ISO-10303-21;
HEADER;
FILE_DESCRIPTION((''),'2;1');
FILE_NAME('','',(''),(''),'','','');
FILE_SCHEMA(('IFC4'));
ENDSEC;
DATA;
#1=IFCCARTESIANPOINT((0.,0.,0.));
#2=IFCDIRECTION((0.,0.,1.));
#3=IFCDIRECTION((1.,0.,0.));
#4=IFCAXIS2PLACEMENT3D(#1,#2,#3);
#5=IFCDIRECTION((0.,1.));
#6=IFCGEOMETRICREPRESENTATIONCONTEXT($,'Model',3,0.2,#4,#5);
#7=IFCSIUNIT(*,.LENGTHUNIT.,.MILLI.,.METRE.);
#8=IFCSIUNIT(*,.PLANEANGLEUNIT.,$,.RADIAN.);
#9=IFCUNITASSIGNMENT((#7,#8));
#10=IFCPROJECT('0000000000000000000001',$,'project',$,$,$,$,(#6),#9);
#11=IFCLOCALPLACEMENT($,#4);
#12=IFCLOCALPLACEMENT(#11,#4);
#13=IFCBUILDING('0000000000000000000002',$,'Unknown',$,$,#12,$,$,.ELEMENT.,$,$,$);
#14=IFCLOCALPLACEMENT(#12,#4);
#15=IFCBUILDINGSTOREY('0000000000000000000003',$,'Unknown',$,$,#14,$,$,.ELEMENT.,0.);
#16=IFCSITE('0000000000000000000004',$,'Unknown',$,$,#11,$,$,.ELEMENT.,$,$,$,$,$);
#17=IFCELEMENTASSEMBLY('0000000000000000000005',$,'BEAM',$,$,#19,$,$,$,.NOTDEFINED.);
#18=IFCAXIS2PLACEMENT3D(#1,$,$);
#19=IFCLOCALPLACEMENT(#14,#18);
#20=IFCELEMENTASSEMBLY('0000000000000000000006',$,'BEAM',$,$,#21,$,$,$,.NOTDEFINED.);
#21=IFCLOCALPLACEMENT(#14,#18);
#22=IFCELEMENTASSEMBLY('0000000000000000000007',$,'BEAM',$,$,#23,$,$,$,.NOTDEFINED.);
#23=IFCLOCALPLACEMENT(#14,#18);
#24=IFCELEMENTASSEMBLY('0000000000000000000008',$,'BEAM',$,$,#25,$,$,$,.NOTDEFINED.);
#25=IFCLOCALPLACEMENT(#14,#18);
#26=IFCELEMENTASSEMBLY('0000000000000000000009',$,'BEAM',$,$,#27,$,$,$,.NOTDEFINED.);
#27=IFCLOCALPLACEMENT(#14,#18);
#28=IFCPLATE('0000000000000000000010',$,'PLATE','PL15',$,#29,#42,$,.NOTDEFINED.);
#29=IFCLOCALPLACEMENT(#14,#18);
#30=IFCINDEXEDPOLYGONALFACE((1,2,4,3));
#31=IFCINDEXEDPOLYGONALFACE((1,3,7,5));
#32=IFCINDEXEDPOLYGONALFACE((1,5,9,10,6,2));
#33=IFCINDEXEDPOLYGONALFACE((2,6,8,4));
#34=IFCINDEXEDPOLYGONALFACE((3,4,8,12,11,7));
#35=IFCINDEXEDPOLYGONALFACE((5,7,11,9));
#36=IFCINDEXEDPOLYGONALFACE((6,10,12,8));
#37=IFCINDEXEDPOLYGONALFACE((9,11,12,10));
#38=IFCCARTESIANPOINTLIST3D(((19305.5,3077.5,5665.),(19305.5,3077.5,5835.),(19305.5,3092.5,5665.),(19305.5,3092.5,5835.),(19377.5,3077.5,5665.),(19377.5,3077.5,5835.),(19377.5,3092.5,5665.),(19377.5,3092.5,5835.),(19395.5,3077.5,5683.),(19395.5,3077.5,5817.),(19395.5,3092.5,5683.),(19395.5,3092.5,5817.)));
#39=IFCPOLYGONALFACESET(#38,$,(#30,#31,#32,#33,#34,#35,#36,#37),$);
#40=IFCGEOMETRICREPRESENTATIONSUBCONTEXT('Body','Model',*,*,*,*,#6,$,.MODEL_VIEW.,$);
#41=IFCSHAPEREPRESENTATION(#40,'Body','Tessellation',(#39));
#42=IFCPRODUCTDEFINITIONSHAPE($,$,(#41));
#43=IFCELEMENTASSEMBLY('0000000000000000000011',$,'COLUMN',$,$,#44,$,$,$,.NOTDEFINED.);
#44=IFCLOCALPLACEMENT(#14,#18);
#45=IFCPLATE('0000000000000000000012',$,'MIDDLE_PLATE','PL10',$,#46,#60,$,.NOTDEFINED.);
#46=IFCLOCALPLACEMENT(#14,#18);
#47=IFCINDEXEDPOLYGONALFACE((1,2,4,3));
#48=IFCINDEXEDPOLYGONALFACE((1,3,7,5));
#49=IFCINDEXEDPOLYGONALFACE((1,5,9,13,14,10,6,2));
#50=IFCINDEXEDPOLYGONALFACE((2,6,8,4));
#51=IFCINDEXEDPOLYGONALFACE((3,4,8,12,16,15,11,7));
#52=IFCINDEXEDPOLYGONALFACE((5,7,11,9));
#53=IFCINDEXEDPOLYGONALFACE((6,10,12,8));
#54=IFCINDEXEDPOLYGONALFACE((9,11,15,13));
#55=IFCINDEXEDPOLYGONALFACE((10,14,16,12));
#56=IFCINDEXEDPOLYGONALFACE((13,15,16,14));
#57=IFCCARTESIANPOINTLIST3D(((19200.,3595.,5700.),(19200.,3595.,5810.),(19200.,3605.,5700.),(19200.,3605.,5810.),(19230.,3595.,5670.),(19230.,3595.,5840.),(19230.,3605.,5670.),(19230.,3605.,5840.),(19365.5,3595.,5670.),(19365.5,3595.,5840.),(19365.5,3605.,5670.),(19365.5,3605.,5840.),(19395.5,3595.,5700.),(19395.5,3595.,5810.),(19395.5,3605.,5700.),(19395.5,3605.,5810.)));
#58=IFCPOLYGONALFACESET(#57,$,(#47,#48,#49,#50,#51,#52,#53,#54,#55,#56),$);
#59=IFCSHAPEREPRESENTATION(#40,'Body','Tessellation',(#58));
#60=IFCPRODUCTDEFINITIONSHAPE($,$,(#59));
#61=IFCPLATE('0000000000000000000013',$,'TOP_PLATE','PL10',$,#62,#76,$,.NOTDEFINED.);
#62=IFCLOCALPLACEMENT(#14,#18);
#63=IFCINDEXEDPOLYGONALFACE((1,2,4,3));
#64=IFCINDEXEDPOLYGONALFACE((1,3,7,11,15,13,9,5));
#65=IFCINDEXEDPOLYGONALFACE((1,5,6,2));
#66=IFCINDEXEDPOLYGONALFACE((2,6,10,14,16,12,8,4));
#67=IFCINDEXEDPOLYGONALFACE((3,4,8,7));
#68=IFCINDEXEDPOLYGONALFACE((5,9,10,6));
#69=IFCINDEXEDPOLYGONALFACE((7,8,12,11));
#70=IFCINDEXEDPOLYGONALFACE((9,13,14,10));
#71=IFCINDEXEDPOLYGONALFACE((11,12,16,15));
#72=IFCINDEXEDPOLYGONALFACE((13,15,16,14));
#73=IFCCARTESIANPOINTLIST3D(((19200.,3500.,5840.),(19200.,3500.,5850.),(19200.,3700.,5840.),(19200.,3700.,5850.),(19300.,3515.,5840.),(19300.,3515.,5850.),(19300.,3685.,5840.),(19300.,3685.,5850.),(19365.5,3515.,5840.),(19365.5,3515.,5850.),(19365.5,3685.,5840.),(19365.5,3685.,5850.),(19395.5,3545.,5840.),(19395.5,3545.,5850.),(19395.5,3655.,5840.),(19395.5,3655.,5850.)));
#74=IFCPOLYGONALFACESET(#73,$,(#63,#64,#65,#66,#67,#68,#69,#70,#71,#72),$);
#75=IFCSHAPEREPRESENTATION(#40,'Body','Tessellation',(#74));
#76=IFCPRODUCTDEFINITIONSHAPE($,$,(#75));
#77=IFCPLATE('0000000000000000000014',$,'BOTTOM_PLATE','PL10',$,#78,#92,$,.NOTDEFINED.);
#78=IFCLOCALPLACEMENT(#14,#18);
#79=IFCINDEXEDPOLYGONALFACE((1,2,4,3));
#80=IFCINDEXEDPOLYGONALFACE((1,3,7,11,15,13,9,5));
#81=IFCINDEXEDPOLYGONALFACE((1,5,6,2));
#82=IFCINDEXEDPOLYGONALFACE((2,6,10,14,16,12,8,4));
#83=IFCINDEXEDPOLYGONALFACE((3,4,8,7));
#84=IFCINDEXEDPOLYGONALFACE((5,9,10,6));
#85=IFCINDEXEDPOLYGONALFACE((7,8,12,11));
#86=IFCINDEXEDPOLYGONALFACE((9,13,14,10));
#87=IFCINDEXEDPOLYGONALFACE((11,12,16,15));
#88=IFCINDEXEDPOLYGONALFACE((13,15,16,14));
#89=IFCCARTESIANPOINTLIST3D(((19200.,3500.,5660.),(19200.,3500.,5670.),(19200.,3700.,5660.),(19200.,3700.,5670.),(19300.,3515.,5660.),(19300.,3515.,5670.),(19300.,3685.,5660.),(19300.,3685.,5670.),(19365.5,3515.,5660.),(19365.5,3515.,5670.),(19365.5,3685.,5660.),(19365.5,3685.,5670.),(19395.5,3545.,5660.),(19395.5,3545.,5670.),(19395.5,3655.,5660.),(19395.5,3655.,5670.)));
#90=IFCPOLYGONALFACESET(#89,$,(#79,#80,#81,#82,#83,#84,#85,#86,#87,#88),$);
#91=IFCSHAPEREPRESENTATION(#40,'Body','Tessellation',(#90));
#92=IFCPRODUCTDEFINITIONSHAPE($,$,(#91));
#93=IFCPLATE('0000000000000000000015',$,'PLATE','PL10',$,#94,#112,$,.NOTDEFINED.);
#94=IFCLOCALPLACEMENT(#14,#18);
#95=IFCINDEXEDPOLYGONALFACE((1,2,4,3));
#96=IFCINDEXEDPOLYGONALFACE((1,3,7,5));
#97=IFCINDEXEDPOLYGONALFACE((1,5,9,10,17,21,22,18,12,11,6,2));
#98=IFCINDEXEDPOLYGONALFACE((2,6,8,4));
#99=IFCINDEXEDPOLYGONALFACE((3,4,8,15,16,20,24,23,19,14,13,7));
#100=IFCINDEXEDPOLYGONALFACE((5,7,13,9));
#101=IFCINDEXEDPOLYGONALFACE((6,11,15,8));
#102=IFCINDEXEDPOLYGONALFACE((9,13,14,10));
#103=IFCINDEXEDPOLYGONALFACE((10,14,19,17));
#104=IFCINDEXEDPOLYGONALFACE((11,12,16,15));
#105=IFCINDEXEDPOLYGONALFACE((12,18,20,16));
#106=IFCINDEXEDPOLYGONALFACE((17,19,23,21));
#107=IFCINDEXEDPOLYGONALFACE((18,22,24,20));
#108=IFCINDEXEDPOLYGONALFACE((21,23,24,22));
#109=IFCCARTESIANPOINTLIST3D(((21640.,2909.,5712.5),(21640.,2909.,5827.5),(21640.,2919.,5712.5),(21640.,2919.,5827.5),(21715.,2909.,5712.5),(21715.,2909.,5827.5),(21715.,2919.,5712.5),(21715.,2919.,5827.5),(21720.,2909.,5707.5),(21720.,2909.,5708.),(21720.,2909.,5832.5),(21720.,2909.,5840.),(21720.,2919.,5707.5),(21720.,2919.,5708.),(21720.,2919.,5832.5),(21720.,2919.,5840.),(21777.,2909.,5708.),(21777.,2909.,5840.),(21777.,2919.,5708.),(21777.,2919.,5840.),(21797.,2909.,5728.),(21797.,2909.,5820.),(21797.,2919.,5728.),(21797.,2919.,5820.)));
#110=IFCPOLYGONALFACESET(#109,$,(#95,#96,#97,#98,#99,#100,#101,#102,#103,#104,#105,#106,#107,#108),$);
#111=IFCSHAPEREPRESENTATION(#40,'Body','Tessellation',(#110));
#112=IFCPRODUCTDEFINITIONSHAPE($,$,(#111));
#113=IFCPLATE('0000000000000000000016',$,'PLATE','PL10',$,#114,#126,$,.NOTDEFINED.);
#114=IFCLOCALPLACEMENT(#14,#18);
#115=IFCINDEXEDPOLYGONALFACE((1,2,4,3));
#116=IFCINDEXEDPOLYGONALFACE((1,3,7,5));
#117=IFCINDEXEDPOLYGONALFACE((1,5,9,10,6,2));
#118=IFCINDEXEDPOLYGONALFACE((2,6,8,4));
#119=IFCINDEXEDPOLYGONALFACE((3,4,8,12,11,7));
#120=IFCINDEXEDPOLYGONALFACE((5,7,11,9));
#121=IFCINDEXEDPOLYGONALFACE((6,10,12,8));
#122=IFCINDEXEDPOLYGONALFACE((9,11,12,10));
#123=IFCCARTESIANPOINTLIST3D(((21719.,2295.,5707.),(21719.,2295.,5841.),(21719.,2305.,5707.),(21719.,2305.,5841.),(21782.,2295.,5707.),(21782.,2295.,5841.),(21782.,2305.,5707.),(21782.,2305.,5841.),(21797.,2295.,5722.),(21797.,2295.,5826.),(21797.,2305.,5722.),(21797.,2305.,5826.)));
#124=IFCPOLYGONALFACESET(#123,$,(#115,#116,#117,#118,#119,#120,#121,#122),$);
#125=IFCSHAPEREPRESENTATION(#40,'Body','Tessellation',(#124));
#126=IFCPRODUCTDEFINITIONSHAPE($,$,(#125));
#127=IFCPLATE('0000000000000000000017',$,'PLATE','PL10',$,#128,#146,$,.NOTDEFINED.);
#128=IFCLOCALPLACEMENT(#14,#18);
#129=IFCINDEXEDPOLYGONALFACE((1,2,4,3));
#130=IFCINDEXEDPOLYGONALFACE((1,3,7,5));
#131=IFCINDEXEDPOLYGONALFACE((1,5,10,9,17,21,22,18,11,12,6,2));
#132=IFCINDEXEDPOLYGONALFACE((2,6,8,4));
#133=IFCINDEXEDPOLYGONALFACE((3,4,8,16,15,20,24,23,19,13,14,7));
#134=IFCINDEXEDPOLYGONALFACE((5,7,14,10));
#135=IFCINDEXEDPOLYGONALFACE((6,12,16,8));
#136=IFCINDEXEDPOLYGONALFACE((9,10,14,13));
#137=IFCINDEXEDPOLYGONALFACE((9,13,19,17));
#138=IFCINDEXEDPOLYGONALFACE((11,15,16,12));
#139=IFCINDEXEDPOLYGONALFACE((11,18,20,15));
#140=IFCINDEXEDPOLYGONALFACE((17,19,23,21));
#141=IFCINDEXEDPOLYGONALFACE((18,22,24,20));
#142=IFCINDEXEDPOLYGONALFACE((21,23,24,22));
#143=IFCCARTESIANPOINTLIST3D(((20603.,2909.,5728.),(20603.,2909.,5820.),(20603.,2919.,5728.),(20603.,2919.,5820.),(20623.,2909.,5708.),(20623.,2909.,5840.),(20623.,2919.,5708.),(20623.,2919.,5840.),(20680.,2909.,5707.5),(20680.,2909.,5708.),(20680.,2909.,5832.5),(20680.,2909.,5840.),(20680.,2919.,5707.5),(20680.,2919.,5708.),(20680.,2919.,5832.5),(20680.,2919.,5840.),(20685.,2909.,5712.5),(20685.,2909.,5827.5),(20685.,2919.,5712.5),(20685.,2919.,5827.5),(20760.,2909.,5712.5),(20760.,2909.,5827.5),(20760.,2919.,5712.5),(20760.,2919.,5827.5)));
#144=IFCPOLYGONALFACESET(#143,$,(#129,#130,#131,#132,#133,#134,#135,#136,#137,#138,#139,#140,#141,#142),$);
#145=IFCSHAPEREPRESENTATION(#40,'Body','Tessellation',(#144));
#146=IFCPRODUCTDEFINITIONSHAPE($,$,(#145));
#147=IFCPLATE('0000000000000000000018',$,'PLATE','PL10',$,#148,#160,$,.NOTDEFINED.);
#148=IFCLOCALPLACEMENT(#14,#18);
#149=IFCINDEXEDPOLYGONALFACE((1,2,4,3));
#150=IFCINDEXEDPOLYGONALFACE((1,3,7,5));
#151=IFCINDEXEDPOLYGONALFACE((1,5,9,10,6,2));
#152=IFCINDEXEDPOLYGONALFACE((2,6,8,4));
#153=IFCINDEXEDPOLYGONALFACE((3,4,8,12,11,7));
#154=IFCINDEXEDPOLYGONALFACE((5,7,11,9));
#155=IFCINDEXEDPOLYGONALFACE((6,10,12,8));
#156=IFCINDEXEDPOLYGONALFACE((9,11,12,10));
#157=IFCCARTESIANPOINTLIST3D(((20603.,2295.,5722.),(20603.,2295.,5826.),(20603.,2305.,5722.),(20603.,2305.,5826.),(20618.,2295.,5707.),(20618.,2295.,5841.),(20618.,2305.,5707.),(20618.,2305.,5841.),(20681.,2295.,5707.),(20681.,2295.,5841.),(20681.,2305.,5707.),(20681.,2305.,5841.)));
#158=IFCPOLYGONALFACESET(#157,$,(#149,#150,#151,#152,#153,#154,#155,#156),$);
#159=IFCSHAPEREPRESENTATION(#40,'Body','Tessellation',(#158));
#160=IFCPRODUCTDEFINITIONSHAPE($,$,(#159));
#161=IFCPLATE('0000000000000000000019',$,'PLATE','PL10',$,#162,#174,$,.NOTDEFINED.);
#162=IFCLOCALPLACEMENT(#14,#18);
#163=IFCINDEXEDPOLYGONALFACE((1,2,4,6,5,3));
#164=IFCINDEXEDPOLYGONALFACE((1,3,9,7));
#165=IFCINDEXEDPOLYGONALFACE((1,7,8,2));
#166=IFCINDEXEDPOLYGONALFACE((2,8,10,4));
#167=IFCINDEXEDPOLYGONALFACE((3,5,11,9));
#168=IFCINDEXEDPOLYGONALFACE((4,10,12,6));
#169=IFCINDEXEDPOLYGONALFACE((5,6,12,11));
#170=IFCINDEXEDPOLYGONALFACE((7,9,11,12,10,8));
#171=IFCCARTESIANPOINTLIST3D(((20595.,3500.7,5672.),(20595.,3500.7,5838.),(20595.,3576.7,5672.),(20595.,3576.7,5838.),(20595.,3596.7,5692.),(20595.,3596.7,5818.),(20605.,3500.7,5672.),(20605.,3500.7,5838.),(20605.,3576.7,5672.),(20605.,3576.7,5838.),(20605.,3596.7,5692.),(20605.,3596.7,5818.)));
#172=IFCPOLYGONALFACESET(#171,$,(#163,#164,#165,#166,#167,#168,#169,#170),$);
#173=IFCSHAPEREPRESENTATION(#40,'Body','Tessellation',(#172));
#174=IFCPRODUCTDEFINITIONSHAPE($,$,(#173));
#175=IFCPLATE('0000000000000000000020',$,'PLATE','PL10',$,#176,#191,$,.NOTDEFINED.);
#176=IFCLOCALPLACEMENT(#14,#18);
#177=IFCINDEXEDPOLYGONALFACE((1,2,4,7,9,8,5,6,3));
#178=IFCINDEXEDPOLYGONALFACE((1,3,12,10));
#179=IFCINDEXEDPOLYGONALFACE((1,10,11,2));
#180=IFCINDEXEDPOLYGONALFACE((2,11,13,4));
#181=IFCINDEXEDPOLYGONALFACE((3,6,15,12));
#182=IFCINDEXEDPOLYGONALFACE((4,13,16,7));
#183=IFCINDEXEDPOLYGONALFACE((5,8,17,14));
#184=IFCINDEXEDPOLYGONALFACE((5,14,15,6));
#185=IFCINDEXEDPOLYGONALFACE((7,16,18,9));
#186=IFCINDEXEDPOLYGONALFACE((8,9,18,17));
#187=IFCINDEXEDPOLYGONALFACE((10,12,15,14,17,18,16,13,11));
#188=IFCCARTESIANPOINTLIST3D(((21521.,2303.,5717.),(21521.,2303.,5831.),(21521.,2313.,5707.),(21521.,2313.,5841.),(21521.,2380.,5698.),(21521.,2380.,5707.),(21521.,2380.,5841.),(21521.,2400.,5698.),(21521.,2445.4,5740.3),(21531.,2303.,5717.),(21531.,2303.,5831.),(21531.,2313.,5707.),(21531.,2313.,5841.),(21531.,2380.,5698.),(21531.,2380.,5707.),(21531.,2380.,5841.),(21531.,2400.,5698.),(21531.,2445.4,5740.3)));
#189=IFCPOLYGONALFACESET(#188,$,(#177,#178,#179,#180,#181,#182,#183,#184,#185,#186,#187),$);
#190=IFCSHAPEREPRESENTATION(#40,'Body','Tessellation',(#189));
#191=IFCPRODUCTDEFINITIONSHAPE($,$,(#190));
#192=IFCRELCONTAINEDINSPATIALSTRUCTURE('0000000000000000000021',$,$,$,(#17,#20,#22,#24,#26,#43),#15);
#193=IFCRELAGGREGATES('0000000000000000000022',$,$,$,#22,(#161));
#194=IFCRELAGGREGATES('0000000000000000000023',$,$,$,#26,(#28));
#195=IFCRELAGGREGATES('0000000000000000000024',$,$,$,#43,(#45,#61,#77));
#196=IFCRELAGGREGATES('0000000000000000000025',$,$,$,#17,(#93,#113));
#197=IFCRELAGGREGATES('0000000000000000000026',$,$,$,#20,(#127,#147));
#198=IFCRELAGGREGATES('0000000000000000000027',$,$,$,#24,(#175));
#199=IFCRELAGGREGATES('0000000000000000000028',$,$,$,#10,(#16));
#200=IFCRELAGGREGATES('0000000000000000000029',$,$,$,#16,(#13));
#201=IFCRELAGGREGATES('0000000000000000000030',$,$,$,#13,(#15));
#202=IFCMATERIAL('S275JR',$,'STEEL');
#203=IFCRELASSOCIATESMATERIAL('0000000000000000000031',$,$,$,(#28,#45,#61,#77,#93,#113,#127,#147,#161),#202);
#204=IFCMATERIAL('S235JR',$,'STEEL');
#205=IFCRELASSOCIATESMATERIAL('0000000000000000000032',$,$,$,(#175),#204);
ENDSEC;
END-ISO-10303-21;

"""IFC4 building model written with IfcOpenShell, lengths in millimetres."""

from ifc_helpers import new_model, si_unit, direction, frame, origin_with_axes, place, context, subcontext, project, spatial, line, indexed_curve, outline, extrude, material, element, aggregate, save


model = new_model("IFC4")

# Units and contexts
model_context = context("Model", 3, precision=0.2, world=origin_with_axes(), true_north=direction((0.0, 1.0)))
body_context = subcontext(model_context, "Body", "Model", "MODEL_VIEW")
ifc_project = project(units=[si_unit("LENGTHUNIT", "METRE", prefix="MILLI"), si_unit("PLANEANGLEUNIT", "RADIAN")], contexts=[model_context])

# Site, building, storey
site_placement = place(None, origin_with_axes())
site = spatial("IfcSite", under=ifc_project, at=site_placement, Name="Unknown", CompositionType="ELEMENT")
building_placement = place(site_placement, origin_with_axes())
building = spatial("IfcBuilding", under=site, at=building_placement, Name="Unknown", CompositionType="ELEMENT")
storey_placement = place(building_placement, origin_with_axes())
storey = spatial("IfcBuildingStorey", under=building, at=storey_placement, Name="Unknown", CompositionType="ELEMENT", Elevation=0.0)

# Element assembly
assembly_1_placement = place(storey_placement, frame((21800.0, 3600.0, 5774.0), z_axis=(-1.0, 0.0, 0.0), x_axis=(-0.000002, -1.0, 0.0)))
assembly_1 = element("IfcElementAssembly", 1, at=assembly_1_placement, inside=storey, Name="BEAM", PredefinedType="NOTDEFINED")
ifc_material_1 = material(Name="S275JR", Category="STEEL")

# Element assembly
assembly_2_placement = place(storey_placement, frame((20600.0, 3600.0, 5774.0), z_axis=(-1.0, 0.0, 0.0), x_axis=(-0.000002, -1.0, 0.0)))
assembly_2 = element("IfcElementAssembly", 2, at=assembly_2_placement, inside=storey, Name="BEAM", PredefinedType="NOTDEFINED")

# Element assembly
assembly_3_placement = place(storey_placement, frame((19400.0, 3600.0, 5755.0), z_axis=(-0.000002, -1.0, 0.0), x_axis=(1.0, 0.0, 0.0)))
assembly_3 = element("IfcElementAssembly", 3, at=assembly_3_placement, inside=storey, Name="BEAM", PredefinedType="NOTDEFINED")

# Element assembly
assembly_4_placement = place(storey_placement, frame((20600.0, 2300.0, 5774.0), z_axis=(-0.000002, -1.0, 0.0), x_axis=(1.0, 0.0, 0.0)))
assembly_4 = element("IfcElementAssembly", 4, at=assembly_4_placement, inside=storey, Name="BEAM", PredefinedType="NOTDEFINED")

# Shared definitions
ifc_material_2 = material(Name="S235JR", Category="STEEL")

# Element assembly, plate
assembly_5_placement = place(storey_placement, frame((19400.0, 0.0, 5750.0), z_axis=(1.0, 0.0, 0.0), x_axis=(0.0, 1.0, 0.0)))
assembly_5 = element("IfcElementAssembly", 5, at=assembly_5_placement, inside=storey, Name="BEAM", PredefinedType="NOTDEFINED")
plate_1_placement = place(assembly_5_placement, frame((3085.0, -85.0, -4.5), z_axis=(1.0, 0.0, 0.0), x_axis=(0.0, -0.000002, -1.0)))
plate_1 = element("IfcPlate", 6, at=plate_1_placement, material=ifc_material_1, Name="PLATE", Description="PL15", PredefinedType="NOTDEFINED", context=body_context, shape_type="SolidModel", body=[
    extrude(outline(indexed_curve([(0.0, 18.0), (18.0, 0.0), (90.0, 0.0), (90.0, 170.0), (18.0, 170.0), (0.0, 152.0)], segments=[line(1, 2, 3, 4, 5, 6, 1)])), frame((0.0, 0.0, 7.5), z_axis=(0.0, 0.0, 1.0), x_axis=(1.0, 0.0, 0.0)), (0.0, -0.000002, -1.0), 15.0),
])

# Element assembly, plates
assembly_6_placement = place(storey_placement, frame((19400.0, 3600.0, 200.0), z_axis=(-1.0, 0.0, 0.0), x_axis=(0.0, 0.0, 1.0)))
assembly_6 = element("IfcElementAssembly", 7, at=assembly_6_placement, inside=storey, Name="COLUMN", PredefinedType="NOTDEFINED")
plate_2_placement = place(assembly_6_placement, frame((5640.0, 0.0, 200.0), z_axis=(0.0, 1.0, 0.0), x_axis=(0.0, -0.000002, -1.0)))
plate_2 = element("IfcPlate", 8, at=plate_2_placement, material=ifc_material_1, Name="MIDDLE_PLATE", Description="PL10", PredefinedType="NOTDEFINED", context=body_context, shape_type="SolidModel", body=[
    extrude(outline(indexed_curve([(0.0, 30.0), (30.0, 0.0), (165.5, 0.0), (195.5, 30.0), (195.5, 140.0), (165.5, 170.0), (30.0, 170.0), (0.0, 140.0)], segments=[line(1, 2, 3, 4, 5, 6, 7, 8, 1)])), frame((0.0, 0.0, 5.0), z_axis=(0.0, 0.0, 1.0), x_axis=(1.0, 0.0, 0.0)), (0.0, -0.000002, -1.0), 10.0),
])
plate_3_placement = place(assembly_6_placement, frame((5645.0, -85.0, 100.0), z_axis=(1.0, 0.0, 0.0), x_axis=(0.0, -0.000002, -1.0)))
plate_3 = element("IfcPlate", 9, at=plate_3_placement, material=ifc_material_1, Name="TOP_PLATE", Description="PL10", PredefinedType="NOTDEFINED", context=body_context, shape_type="SolidModel", body=[
    extrude(outline(indexed_curve([(0.0, 0.0), (65.5, 0.0), (95.5, 30.0), (95.5, 140.0), (65.5, 170.0), (0.0, 170.0), (-100.0, 185.0), (-100.0, -15.0)], segments=[line(1, 2, 3, 4, 5, 6, 7, 8, 1)])), frame((0.0, 0.0, 5.0), z_axis=(0.0, 0.0, 1.0), x_axis=(1.0, 0.0, 0.0)), (0.0, -0.000002, -1.0), 10.0),
])
plate_4_placement = place(assembly_6_placement, frame((5465.0, -85.0, 4.5), z_axis=(1.0, 0.0, 0.0), x_axis=(0.0, 1.0, 0.0)))
plate_4 = element("IfcPlate", 10, at=plate_4_placement, material=ifc_material_1, Name="BOTTOM_PLATE", Description="PL10", PredefinedType="NOTDEFINED", context=body_context, shape_type="SolidModel", body=[
    extrude(outline(indexed_curve([(0.0, 30.0), (30.0, 0.0), (140.0, 0.0), (170.0, 30.0), (170.0, 95.5), (185.0, 195.5), (-15.0, 195.5), (0.0, 95.5)], segments=[line(1, 2, 3, 4, 5, 6, 7, 8, 1)])), frame((0.0, 0.0, 5.0), z_axis=(0.0, 0.0, 1.0), x_axis=(1.0, 0.0, 0.0)), (0.0, -0.000002, -1.0), 10.0),
])

# Plates
plate_5_placement = place(assembly_1_placement, frame((686.0, -46.0, 3.0), z_axis=(-1.0, 0.0, 0.0), x_axis=(0.0, -0.707107, 0.707107)))
plate_5 = element("IfcPlate", 11, at=plate_5_placement, material=ifc_material_1, Name="PLATE", Description="PL10", PredefinedType="NOTDEFINED", context=body_context, shape_type="SolidModel", body=[
    extrude(outline(indexed_curve([(0.0, 0.0), (28.3, 0.0), (68.6, 40.3), (68.9, 40.0), (68.9, 47.0), (122.0, 100.1), (40.7, 181.4), (-12.4, 128.3), (-19.4, 128.3), (-24.7, 133.6), (-65.1, 93.3), (-65.1, 65.1)], segments=[line(1, 2, 3, 4, 5, 6, 7, 8, 9, 10, 11, 12, 1)])), frame((0.0, 0.0, 5.0), z_axis=(0.0, 0.0, 1.0), x_axis=(1.0, 0.0, 0.0)), (0.0, -0.000002, -1.0), 10.0),
])
plate_6_placement = place(assembly_1_placement, frame((1300.0, -67.0, 3.0), z_axis=(-1.0, 0.0, 0.0), x_axis=(0.0, 0.0, 1.0)))
plate_6 = element("IfcPlate", 12, at=plate_6_placement, material=ifc_material_1, Name="PLATE", Description="PL10", PredefinedType="NOTDEFINED", context=body_context, shape_type="SolidModel", body=[
    extrude(outline(indexed_curve([(0.0, 15.0), (15.0, 0.0), (78.0, 0.0), (78.0, 134.0), (15.0, 134.0), (0.0, 119.0)], segments=[line(1, 2, 3, 4, 5, 6, 1)])), frame((0.0, 0.0, 5.0), z_axis=(0.0, 0.0, 1.0), x_axis=(1.0, 0.0, 0.0)), (0.0, -0.000002, -1.0), 10.0),
])
plate_7_placement = place(assembly_2_placement, frame((686.0, -46.0, -3.0), z_axis=(1.0, 0.0, 0.0), x_axis=(0.0, -0.707107, -0.707107)))
plate_7 = element("IfcPlate", 13, at=plate_7_placement, material=ifc_material_1, Name="PLATE", Description="PL10", PredefinedType="NOTDEFINED", context=body_context, shape_type="SolidModel", body=[
    extrude(outline(indexed_curve([(0.0, 0.0), (28.3, 0.0), (68.6, 40.3), (68.9, 40.0), (68.9, 47.0), (122.0, 100.1), (40.7, 181.4), (-12.4, 128.3), (-19.4, 128.3), (-24.7, 133.6), (-65.1, 93.3), (-65.1, 65.1)], segments=[line(1, 2, 3, 4, 5, 6, 7, 8, 9, 10, 11, 12, 1)])), frame((0.0, 0.0, 5.0), z_axis=(0.0, 0.0, 1.0), x_axis=(1.0, 0.0, 0.0)), (0.0, -0.000002, -1.0), 10.0),
])
plate_8_placement = place(assembly_2_placement, frame((1300.0, -67.0, -3.0), z_axis=(1.0, 0.0, 0.0), x_axis=(0.0, -0.000002, -1.0)))
plate_8 = element("IfcPlate", 14, at=plate_8_placement, material=ifc_material_1, Name="PLATE", Description="PL10", PredefinedType="NOTDEFINED", context=body_context, shape_type="SolidModel", body=[
    extrude(outline(indexed_curve([(0.0, 15.0), (15.0, 0.0), (78.0, 0.0), (78.0, 134.0), (15.0, 134.0), (0.0, 119.0)], segments=[line(1, 2, 3, 4, 5, 6, 1)])), frame((0.0, 0.0, 5.0), z_axis=(0.0, 0.0, 1.0), x_axis=(1.0, 0.0, 0.0)), (0.0, -0.000002, -1.0), 10.0),
])
plate_9_placement = place(assembly_3_placement, frame((1200.0, -83.0, 3.2), z_axis=(-1.0, 0.0, 0.0), x_axis=(0.0, 0.0, 1.0)))
plate_9 = element("IfcPlate", 15, at=plate_9_placement, material=ifc_material_1, Name="PLATE", Description="PL10", PredefinedType="NOTDEFINED", context=body_context, shape_type="SolidModel", body=[
    extrude(outline(indexed_curve([(0.0, 20.0), (20.0, 0.0), (96.0, 0.0), (96.0, 166.0), (20.0, 166.0), (0.0, 146.0)], segments=[line(1, 2, 3, 4, 5, 6, 1)])), frame((0.0, 0.0, 5.0), z_axis=(0.0, 0.0, 1.0), x_axis=(1.0, 0.0, 0.0)), (0.0, -0.000002, -1.0), 10.0),
])
aggregate(assembly_3, [plate_9])
plate_10_placement = place(assembly_4_placement, frame((926.0, 67.0, -80.0), z_axis=(1.0, 0.0, 0.0), x_axis=(0.0, 0.0, 1.0)))
plate_10 = element("IfcPlate", 16, at=plate_10_placement, material=ifc_material_2, Name="PLATE", Description="PL10", PredefinedType="NOTDEFINED", context=body_context, shape_type="SolidModel", body=[
    extrude(outline(indexed_curve([(0.0, 0.0), (67.0, 0.0), (77.0, 10.0), (77.0, 124.0), (67.0, 134.0), (0.0, 134.0), (0.0, 143.0), (-20.0, 143.0), (-65.4, 100.7)], segments=[line(1, 2, 3, 4, 5, 6, 7, 8, 9, 1)])), frame((0.0, 0.0, 5.0), z_axis=(0.0, 0.0, 1.0), x_axis=(1.0, 0.0, 0.0)), (0.0, -0.000002, -1.0), 10.0),
])

aggregate(assembly_5, [plate_1])
aggregate(assembly_6, [plate_2, plate_3, plate_4])
aggregate(assembly_1, [plate_5, plate_6])
aggregate(assembly_2, [plate_7, plate_8])
aggregate(assembly_4, [plate_10])

save(model, "model.ifc")
